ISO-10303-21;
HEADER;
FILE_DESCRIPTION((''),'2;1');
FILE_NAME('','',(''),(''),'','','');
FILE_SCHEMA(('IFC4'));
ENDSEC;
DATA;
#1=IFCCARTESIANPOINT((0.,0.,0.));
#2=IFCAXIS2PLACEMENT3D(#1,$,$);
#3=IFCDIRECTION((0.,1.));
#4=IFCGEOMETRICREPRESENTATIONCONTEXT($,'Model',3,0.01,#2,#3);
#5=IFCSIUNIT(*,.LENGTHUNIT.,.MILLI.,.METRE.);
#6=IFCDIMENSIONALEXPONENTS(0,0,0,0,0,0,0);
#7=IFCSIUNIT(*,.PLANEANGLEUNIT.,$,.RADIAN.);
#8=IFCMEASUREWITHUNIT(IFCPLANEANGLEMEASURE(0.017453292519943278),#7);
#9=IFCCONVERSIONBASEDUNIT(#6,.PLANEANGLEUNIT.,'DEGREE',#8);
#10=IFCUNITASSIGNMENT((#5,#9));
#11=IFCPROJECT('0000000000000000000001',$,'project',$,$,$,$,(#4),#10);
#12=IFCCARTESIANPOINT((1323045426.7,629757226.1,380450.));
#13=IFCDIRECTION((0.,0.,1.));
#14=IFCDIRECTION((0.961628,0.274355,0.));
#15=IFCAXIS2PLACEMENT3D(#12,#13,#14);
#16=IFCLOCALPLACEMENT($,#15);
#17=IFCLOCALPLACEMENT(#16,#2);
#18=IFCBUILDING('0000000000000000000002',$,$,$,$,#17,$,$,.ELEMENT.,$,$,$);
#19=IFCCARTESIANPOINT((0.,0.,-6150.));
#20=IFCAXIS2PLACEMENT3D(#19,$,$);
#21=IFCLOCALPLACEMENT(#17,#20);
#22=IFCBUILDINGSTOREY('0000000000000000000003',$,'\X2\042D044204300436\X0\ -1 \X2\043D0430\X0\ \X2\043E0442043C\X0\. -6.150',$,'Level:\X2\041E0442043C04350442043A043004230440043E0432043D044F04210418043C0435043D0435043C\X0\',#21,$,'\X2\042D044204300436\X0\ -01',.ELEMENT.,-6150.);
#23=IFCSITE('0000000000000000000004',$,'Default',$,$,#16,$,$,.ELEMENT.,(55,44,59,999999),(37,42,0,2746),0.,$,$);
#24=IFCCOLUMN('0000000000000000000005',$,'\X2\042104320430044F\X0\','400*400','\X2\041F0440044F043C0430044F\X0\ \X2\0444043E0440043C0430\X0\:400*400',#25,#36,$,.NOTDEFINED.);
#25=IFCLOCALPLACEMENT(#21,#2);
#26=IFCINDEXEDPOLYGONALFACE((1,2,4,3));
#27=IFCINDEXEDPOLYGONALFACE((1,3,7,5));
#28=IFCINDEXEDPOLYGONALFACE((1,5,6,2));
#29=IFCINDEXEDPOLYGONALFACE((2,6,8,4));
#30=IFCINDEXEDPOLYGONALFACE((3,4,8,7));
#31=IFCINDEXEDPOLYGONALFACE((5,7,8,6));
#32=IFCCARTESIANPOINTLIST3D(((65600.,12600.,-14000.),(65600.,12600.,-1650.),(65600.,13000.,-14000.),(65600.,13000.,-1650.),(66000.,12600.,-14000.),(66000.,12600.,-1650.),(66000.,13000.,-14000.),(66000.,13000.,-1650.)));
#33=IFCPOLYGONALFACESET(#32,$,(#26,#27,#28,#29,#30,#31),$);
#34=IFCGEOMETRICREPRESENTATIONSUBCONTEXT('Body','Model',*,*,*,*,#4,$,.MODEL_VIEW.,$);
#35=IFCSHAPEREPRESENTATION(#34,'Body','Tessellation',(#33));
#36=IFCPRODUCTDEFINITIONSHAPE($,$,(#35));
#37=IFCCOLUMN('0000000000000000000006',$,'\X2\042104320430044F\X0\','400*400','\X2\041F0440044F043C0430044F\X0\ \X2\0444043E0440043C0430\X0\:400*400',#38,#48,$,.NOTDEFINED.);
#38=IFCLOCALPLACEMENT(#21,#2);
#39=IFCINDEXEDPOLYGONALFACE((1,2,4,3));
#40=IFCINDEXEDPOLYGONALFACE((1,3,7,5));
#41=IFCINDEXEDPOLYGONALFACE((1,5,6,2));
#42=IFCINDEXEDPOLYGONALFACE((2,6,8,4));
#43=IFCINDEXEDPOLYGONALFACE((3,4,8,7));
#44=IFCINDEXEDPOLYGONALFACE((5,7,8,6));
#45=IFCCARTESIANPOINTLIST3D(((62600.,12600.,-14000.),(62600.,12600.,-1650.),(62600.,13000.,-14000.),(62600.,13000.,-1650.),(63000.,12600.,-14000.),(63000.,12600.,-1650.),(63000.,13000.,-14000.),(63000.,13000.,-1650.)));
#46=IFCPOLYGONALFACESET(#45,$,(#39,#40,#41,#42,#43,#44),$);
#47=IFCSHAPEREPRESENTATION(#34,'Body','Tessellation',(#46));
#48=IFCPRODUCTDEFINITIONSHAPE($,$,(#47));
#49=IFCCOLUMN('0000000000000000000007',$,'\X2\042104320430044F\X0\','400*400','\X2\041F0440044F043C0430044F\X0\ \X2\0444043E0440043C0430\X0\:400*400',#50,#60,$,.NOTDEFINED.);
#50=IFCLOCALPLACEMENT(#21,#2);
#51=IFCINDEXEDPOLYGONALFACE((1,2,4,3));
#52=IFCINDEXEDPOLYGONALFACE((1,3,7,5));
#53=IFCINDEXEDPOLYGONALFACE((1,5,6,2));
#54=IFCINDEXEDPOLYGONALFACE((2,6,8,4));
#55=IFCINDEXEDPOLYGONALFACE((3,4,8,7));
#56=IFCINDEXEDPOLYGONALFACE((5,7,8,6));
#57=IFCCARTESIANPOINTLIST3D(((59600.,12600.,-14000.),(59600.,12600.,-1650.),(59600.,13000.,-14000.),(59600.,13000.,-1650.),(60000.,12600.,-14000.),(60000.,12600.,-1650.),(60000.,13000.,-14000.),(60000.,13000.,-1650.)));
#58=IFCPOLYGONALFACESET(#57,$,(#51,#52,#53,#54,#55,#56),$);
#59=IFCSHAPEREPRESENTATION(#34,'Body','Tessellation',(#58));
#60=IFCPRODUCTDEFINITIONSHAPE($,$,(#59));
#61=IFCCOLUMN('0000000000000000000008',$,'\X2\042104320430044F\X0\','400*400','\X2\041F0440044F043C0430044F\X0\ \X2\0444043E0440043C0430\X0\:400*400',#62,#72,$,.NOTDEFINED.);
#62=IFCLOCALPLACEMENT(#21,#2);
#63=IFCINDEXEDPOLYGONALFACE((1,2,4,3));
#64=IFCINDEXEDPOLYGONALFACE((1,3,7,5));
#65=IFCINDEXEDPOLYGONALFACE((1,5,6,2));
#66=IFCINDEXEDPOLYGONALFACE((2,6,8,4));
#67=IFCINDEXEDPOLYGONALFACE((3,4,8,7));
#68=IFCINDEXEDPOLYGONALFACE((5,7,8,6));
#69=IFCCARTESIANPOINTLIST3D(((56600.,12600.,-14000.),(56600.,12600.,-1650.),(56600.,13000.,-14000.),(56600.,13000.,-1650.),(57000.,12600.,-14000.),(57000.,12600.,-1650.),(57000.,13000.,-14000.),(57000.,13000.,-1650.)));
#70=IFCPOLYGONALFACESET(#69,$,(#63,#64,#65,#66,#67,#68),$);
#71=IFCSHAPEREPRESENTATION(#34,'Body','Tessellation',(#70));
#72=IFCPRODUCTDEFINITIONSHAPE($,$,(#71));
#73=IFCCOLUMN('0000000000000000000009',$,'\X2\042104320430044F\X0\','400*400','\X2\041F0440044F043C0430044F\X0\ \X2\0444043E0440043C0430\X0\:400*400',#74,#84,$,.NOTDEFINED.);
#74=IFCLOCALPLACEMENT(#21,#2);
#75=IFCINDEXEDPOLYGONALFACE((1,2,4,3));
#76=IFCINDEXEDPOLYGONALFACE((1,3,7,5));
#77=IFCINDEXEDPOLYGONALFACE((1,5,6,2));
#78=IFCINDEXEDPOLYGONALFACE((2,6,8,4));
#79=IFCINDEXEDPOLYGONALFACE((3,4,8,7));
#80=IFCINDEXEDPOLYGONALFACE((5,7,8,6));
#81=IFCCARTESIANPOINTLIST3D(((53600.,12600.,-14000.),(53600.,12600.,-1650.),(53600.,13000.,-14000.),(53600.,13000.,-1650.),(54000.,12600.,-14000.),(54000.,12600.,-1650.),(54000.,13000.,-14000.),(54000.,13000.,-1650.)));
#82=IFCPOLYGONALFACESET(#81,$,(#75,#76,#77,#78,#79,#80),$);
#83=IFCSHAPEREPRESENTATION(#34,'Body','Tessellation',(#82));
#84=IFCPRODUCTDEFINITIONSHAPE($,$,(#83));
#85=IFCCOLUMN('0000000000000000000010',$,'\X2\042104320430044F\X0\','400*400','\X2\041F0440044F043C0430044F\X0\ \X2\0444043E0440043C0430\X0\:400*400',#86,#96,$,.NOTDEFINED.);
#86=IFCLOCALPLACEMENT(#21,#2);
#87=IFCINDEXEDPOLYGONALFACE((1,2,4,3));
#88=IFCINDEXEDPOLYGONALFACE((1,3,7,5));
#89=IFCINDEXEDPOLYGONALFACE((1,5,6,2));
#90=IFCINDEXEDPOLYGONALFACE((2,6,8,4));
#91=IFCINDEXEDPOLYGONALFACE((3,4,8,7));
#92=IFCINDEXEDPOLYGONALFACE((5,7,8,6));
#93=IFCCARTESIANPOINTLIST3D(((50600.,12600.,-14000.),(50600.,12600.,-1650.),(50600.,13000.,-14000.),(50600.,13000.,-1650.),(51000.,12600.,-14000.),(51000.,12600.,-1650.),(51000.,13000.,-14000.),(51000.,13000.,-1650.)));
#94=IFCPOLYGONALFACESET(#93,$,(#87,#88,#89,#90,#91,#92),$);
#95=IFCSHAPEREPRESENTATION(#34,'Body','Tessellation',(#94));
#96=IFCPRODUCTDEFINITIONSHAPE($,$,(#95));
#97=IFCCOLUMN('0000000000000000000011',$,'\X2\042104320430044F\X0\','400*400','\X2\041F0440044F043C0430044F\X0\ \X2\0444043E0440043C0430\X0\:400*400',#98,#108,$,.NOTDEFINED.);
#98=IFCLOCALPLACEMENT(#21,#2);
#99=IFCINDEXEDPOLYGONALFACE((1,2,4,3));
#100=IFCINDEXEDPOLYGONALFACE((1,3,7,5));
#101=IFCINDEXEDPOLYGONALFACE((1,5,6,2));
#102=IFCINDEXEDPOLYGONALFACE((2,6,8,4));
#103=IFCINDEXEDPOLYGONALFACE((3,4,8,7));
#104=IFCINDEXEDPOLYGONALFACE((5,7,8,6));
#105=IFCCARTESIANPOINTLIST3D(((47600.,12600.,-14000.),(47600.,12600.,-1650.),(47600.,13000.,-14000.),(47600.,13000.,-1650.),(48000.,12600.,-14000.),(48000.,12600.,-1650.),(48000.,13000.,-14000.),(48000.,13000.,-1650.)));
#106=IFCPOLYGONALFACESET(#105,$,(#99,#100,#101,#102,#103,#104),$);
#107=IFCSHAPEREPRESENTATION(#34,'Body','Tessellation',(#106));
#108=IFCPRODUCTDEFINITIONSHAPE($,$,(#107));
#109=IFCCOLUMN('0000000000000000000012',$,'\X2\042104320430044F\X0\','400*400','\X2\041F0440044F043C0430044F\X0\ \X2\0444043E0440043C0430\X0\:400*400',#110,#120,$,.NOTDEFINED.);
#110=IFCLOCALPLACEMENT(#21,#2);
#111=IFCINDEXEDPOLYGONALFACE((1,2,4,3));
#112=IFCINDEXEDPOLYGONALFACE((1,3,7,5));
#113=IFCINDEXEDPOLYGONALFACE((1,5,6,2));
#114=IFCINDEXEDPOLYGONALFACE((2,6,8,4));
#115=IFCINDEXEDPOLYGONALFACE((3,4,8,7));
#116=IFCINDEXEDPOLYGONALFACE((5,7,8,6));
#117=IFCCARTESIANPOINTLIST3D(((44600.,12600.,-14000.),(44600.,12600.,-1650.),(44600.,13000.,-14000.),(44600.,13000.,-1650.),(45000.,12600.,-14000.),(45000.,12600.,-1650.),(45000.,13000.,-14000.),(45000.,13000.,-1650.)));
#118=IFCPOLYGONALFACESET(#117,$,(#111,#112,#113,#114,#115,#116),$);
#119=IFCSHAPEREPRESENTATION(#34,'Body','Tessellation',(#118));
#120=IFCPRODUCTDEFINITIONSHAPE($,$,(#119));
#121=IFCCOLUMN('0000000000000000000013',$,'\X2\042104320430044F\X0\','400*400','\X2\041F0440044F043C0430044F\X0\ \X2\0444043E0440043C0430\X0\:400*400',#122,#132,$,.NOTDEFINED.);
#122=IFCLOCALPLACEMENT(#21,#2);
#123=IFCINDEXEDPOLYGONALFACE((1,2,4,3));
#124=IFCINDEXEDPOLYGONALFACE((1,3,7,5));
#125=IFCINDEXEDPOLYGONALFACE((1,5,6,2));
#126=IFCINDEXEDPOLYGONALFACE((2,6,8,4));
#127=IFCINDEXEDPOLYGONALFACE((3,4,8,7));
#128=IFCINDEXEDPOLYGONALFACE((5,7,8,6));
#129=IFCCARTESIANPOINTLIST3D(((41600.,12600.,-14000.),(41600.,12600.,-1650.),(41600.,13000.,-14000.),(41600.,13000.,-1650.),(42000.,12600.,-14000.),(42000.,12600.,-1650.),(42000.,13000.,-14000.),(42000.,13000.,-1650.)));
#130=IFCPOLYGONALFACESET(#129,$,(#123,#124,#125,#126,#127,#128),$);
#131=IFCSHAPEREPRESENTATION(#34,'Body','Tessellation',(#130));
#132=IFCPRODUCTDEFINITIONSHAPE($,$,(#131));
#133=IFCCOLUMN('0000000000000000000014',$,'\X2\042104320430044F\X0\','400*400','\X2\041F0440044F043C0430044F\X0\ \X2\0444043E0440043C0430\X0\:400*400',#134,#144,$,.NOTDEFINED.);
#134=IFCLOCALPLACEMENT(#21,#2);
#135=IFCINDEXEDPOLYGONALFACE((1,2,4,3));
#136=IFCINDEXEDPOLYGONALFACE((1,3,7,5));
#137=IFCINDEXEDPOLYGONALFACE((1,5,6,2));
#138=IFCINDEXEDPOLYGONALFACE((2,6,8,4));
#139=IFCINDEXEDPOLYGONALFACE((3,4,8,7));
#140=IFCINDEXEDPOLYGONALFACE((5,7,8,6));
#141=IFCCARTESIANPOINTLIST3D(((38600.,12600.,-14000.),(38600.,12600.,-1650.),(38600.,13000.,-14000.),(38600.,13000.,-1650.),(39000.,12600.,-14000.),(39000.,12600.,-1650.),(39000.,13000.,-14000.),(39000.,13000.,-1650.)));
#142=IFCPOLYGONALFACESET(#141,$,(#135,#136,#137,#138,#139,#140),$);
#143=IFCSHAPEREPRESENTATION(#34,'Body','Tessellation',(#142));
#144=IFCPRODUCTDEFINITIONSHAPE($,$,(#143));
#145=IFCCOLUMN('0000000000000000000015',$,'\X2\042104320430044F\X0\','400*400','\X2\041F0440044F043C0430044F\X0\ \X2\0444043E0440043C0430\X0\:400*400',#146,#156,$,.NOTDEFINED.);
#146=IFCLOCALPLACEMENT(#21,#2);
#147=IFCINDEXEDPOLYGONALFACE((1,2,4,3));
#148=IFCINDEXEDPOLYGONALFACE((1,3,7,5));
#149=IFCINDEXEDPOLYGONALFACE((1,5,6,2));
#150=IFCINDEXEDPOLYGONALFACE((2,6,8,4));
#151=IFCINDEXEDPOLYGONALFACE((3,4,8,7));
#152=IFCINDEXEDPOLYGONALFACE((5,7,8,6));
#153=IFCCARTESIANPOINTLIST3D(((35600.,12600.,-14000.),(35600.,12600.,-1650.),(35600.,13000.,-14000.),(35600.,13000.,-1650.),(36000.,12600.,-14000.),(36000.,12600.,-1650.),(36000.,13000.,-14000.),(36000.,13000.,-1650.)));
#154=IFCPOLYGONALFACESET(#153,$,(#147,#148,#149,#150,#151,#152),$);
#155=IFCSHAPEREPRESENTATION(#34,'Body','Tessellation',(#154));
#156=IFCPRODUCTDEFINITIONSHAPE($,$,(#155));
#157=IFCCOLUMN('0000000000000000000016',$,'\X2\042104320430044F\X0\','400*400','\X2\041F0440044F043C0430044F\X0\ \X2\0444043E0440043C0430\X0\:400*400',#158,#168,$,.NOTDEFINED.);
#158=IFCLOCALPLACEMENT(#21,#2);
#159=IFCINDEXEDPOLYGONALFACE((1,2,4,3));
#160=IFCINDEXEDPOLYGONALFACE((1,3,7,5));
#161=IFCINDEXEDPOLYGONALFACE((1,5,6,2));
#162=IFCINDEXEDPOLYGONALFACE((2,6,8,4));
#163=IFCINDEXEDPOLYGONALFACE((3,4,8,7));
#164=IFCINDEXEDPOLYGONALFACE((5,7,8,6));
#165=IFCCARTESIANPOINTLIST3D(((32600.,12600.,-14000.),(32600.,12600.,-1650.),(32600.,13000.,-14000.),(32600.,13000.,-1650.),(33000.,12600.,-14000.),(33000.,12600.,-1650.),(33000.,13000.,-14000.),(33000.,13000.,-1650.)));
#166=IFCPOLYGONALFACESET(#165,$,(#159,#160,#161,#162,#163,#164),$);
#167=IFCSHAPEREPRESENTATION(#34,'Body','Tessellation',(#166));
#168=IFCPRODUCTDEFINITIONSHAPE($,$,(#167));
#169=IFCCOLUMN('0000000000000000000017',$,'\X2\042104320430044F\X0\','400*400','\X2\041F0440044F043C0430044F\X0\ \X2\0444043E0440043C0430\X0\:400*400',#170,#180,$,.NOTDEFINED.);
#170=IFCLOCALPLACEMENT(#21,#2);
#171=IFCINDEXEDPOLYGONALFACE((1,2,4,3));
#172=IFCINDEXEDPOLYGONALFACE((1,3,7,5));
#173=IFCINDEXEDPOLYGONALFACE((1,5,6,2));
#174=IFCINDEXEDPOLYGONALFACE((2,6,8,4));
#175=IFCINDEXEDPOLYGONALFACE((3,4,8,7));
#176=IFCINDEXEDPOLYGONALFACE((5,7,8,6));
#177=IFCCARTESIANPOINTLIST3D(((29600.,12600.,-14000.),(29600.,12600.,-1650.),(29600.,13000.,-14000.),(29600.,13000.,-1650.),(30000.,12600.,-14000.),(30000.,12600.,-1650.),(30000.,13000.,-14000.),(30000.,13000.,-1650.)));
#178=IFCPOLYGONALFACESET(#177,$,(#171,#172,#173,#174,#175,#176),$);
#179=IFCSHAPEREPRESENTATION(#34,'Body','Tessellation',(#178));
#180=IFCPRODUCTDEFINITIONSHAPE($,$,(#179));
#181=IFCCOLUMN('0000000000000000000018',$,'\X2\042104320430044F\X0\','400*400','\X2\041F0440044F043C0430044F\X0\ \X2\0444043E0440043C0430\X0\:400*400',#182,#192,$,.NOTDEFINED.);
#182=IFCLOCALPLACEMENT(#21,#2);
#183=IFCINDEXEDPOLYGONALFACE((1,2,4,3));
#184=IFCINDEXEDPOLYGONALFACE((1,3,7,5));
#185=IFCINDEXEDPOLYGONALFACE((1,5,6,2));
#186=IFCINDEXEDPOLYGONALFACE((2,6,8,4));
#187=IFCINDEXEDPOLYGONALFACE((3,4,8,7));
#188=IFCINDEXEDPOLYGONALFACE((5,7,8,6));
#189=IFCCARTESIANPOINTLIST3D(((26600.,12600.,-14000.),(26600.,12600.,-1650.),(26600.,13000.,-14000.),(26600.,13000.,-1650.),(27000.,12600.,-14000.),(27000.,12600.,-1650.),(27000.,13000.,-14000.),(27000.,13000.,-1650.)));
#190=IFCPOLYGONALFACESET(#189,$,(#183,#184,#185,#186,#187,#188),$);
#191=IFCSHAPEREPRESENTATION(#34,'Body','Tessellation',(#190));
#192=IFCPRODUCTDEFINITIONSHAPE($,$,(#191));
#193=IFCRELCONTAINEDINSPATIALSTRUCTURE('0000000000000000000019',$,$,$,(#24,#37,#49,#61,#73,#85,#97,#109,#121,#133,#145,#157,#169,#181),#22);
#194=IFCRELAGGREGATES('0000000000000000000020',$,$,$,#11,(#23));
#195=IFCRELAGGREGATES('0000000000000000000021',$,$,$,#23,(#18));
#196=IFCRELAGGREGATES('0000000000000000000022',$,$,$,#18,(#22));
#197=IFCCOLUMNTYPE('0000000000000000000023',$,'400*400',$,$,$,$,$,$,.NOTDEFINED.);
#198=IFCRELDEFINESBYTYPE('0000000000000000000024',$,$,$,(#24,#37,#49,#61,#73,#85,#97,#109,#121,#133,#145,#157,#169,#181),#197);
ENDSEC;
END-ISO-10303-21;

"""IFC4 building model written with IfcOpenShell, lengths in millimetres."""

from ifc_helpers import new_model, entity, si_unit, converted_unit, direction, frame, origin, place, context, subcontext, project, spatial, indexed_curve, outline, extrude, type_object, element, save


model = new_model("IFC4")

# Units and contexts
model_context = context("Model", 3, precision=0.01, world=origin(), true_north=direction((0.0, 1.0)))
body_context = subcontext(model_context, "Body", "Model", "MODEL_VIEW")
ifc_project = project(units=[si_unit("LENGTHUNIT", "METRE", prefix="MILLI"), converted_unit("PLANEANGLEUNIT", "DEGREE", entity("IfcPlaneAngleMeasure", 0.017453292519943278), si_unit("PLANEANGLEUNIT", "RADIAN"), dimensions=[0, 0, 0, 0, 0, 0, 0])], contexts=[model_context])

# Site, building, storey
site_placement = place(None, frame((1323045426.7, 629757226.1, 380450.0), z_axis=(0.0, 0.0, 1.0), x_axis=(0.961628, 0.274355, 0.0)))
site = spatial("IfcSite", under=ifc_project, at=site_placement, Name="Default", CompositionType="ELEMENT", RefLatitude=(55, 44, 59, 999999), RefLongitude=(37, 42, 0, 2746), RefElevation=0.0)
building_placement = place(site_placement, origin())
building = spatial("IfcBuilding", under=site, at=building_placement, CompositionType="ELEMENT")
storey_placement = place(building_placement, frame((0.0, 0.0, -6150.0)))
storey = spatial("IfcBuildingStorey", under=building, at=storey_placement, Name="Этаж -1 на отм. -6.150", ObjectType="Level:ОтметкаУровняСИменем", LongName="Этаж -01", CompositionType="ELEMENT", Elevation=-6150.0)

# Columns
column_type = type_object("IfcColumnType", Name="400*400", PredefinedType="NOTDEFINED")
column_1_placement = place(storey_placement, origin())
element("IfcColumn", 1, at=column_1_placement, inside=storey, type_object=column_type, Name="Свая", Description="400*400", ObjectType="Прямая форма:400*400", PredefinedType="NOTDEFINED", context=body_context, shape_type="SweptSolid", body=[
    extrude(outline(indexed_curve([(-200.0, -200.0), (200.0, -200.0), (200.0, 200.0), (-200.0, 200.0), (-200.0, -200.0)], self_intersect=False)), frame((65800.0, 12800.0, -14000.0), z_axis=(0.0, 0.0, 1.0), x_axis=(0.0, 1.0, 0.0)), (0.0, 0.0, 1.0), 12350.0),
])
column_2_placement = place(storey_placement, origin())
element("IfcColumn", 2, at=column_2_placement, inside=storey, type_object=column_type, Name="Свая", Description="400*400", ObjectType="Прямая форма:400*400", PredefinedType="NOTDEFINED", context=body_context, shape_type="SweptSolid", body=[
    extrude(outline(indexed_curve([(-200.0, -200.0), (200.0, -200.0), (200.0, 200.0), (-200.0, 200.0), (-200.0, -200.0)], self_intersect=False)), frame((62800.0, 12800.0, -14000.0), z_axis=(0.0, 0.0, 1.0), x_axis=(0.0, 1.0, 0.0)), (0.0, 0.0, 1.0), 12350.0),
])
column_3_placement = place(storey_placement, origin())
element("IfcColumn", 3, at=column_3_placement, inside=storey, type_object=column_type, Name="Свая", Description="400*400", ObjectType="Прямая форма:400*400", PredefinedType="NOTDEFINED", context=body_context, shape_type="SweptSolid", body=[
    extrude(outline(indexed_curve([(-200.0, -200.0), (200.0, -200.0), (200.0, 200.0), (-200.0, 200.0), (-200.0, -200.0)], self_intersect=False)), frame((59800.0, 12800.0, -14000.0), z_axis=(0.0, 0.0, 1.0), x_axis=(0.0, 1.0, 0.0)), (0.0, 0.0, 1.0), 12350.0),
])
column_4_placement = place(storey_placement, origin())
element("IfcColumn", 4, at=column_4_placement, inside=storey, type_object=column_type, Name="Свая", Description="400*400", ObjectType="Прямая форма:400*400", PredefinedType="NOTDEFINED", context=body_context, shape_type="SweptSolid", body=[
    extrude(outline(indexed_curve([(-200.0, -200.0), (200.0, -200.0), (200.0, 200.0), (-200.0, 200.0), (-200.0, -200.0)], self_intersect=False)), frame((56800.0, 12800.0, -14000.0), z_axis=(0.0, 0.0, 1.0), x_axis=(0.0, 1.0, 0.0)), (0.0, 0.0, 1.0), 12350.0),
])
column_5_placement = place(storey_placement, origin())
element("IfcColumn", 5, at=column_5_placement, inside=storey, type_object=column_type, Name="Свая", Description="400*400", ObjectType="Прямая форма:400*400", PredefinedType="NOTDEFINED", context=body_context, shape_type="SweptSolid", body=[
    extrude(outline(indexed_curve([(-200.0, -200.0), (200.0, -200.0), (200.0, 200.0), (-200.0, 200.0), (-200.0, -200.0)], self_intersect=False)), frame((53800.0, 12800.0, -14000.0), z_axis=(0.0, 0.0, 1.0), x_axis=(0.0, 1.0, 0.0)), (0.0, 0.0, 1.0), 12350.0),
])
column_6_placement = place(storey_placement, origin())
element("IfcColumn", 6, at=column_6_placement, inside=storey, type_object=column_type, Name="Свая", Description="400*400", ObjectType="Прямая форма:400*400", PredefinedType="NOTDEFINED", context=body_context, shape_type="SweptSolid", body=[
    extrude(outline(indexed_curve([(-200.0, -200.0), (200.0, -200.0), (200.0, 200.0), (-200.0, 200.0), (-200.0, -200.0)], self_intersect=False)), frame((50800.0, 12800.0, -14000.0), z_axis=(0.0, 0.0, 1.0), x_axis=(0.0, 1.0, 0.0)), (0.0, 0.0, 1.0), 12350.0),
])
column_7_placement = place(storey_placement, origin())
element("IfcColumn", 7, at=column_7_placement, inside=storey, type_object=column_type, Name="Свая", Description="400*400", ObjectType="Прямая форма:400*400", PredefinedType="NOTDEFINED", context=body_context, shape_type="SweptSolid", body=[
    extrude(outline(indexed_curve([(-200.0, -200.0), (200.0, -200.0), (200.0, 200.0), (-200.0, 200.0), (-200.0, -200.0)], self_intersect=False)), frame((47800.0, 12800.0, -14000.0), z_axis=(0.0, 0.0, 1.0), x_axis=(0.0, 1.0, 0.0)), (0.0, 0.0, 1.0), 12350.0),
])
column_8_placement = place(storey_placement, origin())
element("IfcColumn", 8, at=column_8_placement, inside=storey, type_object=column_type, Name="Свая", Description="400*400", ObjectType="Прямая форма:400*400", PredefinedType="NOTDEFINED", context=body_context, shape_type="SweptSolid", body=[
    extrude(outline(indexed_curve([(-200.0, -200.0), (200.0, -200.0), (200.0, 200.0), (-200.0, 200.0), (-200.0, -200.0)], self_intersect=False)), frame((44800.0, 12800.0, -14000.0), z_axis=(0.0, 0.0, 1.0), x_axis=(0.0, 1.0, 0.0)), (0.0, 0.0, 1.0), 12350.0),
])
column_9_placement = place(storey_placement, origin())
element("IfcColumn", 9, at=column_9_placement, inside=storey, type_object=column_type, Name="Свая", Description="400*400", ObjectType="Прямая форма:400*400", PredefinedType="NOTDEFINED", context=body_context, shape_type="SweptSolid", body=[
    extrude(outline(indexed_curve([(-200.0, -200.0), (200.0, -200.0), (200.0, 200.0), (-200.0, 200.0), (-200.0, -200.0)], self_intersect=False)), frame((41800.0, 12800.0, -14000.0), z_axis=(0.0, 0.0, 1.0), x_axis=(0.0, 1.0, 0.0)), (0.0, 0.0, 1.0), 12350.0),
])
column_10_placement = place(storey_placement, origin())
element("IfcColumn", 10, at=column_10_placement, inside=storey, type_object=column_type, Name="Свая", Description="400*400", ObjectType="Прямая форма:400*400", PredefinedType="NOTDEFINED", context=body_context, shape_type="SweptSolid", body=[
    extrude(outline(indexed_curve([(-200.0, -200.0), (200.0, -200.0), (200.0, 200.0), (-200.0, 200.0), (-200.0, -200.0)], self_intersect=False)), frame((38800.0, 12800.0, -14000.0), z_axis=(0.0, 0.0, 1.0), x_axis=(0.0, 1.0, 0.0)), (0.0, 0.0, 1.0), 12350.0),
])
column_11_placement = place(storey_placement, origin())
element("IfcColumn", 11, at=column_11_placement, inside=storey, type_object=column_type, Name="Свая", Description="400*400", ObjectType="Прямая форма:400*400", PredefinedType="NOTDEFINED", context=body_context, shape_type="SweptSolid", body=[
    extrude(outline(indexed_curve([(-200.0, -200.0), (200.0, -200.0), (200.0, 200.0), (-200.0, 200.0), (-200.0, -200.0)], self_intersect=False)), frame((35800.0, 12800.0, -14000.0), z_axis=(0.0, 0.0, 1.0), x_axis=(0.0, 1.0, 0.0)), (0.0, 0.0, 1.0), 12350.0),
])
column_12_placement = place(storey_placement, origin())
element("IfcColumn", 12, at=column_12_placement, inside=storey, type_object=column_type, Name="Свая", Description="400*400", ObjectType="Прямая форма:400*400", PredefinedType="NOTDEFINED", context=body_context, shape_type="SweptSolid", body=[
    extrude(outline(indexed_curve([(-200.0, -200.0), (200.0, -200.0), (200.0, 200.0), (-200.0, 200.0), (-200.0, -200.0)], self_intersect=False)), frame((32800.0, 12800.0, -14000.0), z_axis=(0.0, 0.0, 1.0), x_axis=(0.0, 1.0, 0.0)), (0.0, 0.0, 1.0), 12350.0),
])
column_13_placement = place(storey_placement, origin())
element("IfcColumn", 13, at=column_13_placement, inside=storey, type_object=column_type, Name="Свая", Description="400*400", ObjectType="Прямая форма:400*400", PredefinedType="NOTDEFINED", context=body_context, shape_type="SweptSolid", body=[
    extrude(outline(indexed_curve([(-200.0, -200.0), (200.0, -200.0), (200.0, 200.0), (-200.0, 200.0), (-200.0, -200.0)], self_intersect=False)), frame((29800.0, 12800.0, -14000.0), z_axis=(0.0, 0.0, 1.0), x_axis=(0.0, 1.0, 0.0)), (0.0, 0.0, 1.0), 12350.0),
])
column_14_placement = place(storey_placement, origin())
element("IfcColumn", 14, at=column_14_placement, inside=storey, type_object=column_type, Name="Свая", Description="400*400", ObjectType="Прямая форма:400*400", PredefinedType="NOTDEFINED", context=body_context, shape_type="SweptSolid", body=[
    extrude(outline(indexed_curve([(-200.0, -200.0), (200.0, -200.0), (200.0, 200.0), (-200.0, 200.0), (-200.0, -200.0)], self_intersect=False)), frame((26800.0, 12800.0, -14000.0), z_axis=(0.0, 0.0, 1.0), x_axis=(0.0, 1.0, 0.0)), (0.0, 0.0, 1.0), 12350.0),
])

save(model, "model.ifc")
